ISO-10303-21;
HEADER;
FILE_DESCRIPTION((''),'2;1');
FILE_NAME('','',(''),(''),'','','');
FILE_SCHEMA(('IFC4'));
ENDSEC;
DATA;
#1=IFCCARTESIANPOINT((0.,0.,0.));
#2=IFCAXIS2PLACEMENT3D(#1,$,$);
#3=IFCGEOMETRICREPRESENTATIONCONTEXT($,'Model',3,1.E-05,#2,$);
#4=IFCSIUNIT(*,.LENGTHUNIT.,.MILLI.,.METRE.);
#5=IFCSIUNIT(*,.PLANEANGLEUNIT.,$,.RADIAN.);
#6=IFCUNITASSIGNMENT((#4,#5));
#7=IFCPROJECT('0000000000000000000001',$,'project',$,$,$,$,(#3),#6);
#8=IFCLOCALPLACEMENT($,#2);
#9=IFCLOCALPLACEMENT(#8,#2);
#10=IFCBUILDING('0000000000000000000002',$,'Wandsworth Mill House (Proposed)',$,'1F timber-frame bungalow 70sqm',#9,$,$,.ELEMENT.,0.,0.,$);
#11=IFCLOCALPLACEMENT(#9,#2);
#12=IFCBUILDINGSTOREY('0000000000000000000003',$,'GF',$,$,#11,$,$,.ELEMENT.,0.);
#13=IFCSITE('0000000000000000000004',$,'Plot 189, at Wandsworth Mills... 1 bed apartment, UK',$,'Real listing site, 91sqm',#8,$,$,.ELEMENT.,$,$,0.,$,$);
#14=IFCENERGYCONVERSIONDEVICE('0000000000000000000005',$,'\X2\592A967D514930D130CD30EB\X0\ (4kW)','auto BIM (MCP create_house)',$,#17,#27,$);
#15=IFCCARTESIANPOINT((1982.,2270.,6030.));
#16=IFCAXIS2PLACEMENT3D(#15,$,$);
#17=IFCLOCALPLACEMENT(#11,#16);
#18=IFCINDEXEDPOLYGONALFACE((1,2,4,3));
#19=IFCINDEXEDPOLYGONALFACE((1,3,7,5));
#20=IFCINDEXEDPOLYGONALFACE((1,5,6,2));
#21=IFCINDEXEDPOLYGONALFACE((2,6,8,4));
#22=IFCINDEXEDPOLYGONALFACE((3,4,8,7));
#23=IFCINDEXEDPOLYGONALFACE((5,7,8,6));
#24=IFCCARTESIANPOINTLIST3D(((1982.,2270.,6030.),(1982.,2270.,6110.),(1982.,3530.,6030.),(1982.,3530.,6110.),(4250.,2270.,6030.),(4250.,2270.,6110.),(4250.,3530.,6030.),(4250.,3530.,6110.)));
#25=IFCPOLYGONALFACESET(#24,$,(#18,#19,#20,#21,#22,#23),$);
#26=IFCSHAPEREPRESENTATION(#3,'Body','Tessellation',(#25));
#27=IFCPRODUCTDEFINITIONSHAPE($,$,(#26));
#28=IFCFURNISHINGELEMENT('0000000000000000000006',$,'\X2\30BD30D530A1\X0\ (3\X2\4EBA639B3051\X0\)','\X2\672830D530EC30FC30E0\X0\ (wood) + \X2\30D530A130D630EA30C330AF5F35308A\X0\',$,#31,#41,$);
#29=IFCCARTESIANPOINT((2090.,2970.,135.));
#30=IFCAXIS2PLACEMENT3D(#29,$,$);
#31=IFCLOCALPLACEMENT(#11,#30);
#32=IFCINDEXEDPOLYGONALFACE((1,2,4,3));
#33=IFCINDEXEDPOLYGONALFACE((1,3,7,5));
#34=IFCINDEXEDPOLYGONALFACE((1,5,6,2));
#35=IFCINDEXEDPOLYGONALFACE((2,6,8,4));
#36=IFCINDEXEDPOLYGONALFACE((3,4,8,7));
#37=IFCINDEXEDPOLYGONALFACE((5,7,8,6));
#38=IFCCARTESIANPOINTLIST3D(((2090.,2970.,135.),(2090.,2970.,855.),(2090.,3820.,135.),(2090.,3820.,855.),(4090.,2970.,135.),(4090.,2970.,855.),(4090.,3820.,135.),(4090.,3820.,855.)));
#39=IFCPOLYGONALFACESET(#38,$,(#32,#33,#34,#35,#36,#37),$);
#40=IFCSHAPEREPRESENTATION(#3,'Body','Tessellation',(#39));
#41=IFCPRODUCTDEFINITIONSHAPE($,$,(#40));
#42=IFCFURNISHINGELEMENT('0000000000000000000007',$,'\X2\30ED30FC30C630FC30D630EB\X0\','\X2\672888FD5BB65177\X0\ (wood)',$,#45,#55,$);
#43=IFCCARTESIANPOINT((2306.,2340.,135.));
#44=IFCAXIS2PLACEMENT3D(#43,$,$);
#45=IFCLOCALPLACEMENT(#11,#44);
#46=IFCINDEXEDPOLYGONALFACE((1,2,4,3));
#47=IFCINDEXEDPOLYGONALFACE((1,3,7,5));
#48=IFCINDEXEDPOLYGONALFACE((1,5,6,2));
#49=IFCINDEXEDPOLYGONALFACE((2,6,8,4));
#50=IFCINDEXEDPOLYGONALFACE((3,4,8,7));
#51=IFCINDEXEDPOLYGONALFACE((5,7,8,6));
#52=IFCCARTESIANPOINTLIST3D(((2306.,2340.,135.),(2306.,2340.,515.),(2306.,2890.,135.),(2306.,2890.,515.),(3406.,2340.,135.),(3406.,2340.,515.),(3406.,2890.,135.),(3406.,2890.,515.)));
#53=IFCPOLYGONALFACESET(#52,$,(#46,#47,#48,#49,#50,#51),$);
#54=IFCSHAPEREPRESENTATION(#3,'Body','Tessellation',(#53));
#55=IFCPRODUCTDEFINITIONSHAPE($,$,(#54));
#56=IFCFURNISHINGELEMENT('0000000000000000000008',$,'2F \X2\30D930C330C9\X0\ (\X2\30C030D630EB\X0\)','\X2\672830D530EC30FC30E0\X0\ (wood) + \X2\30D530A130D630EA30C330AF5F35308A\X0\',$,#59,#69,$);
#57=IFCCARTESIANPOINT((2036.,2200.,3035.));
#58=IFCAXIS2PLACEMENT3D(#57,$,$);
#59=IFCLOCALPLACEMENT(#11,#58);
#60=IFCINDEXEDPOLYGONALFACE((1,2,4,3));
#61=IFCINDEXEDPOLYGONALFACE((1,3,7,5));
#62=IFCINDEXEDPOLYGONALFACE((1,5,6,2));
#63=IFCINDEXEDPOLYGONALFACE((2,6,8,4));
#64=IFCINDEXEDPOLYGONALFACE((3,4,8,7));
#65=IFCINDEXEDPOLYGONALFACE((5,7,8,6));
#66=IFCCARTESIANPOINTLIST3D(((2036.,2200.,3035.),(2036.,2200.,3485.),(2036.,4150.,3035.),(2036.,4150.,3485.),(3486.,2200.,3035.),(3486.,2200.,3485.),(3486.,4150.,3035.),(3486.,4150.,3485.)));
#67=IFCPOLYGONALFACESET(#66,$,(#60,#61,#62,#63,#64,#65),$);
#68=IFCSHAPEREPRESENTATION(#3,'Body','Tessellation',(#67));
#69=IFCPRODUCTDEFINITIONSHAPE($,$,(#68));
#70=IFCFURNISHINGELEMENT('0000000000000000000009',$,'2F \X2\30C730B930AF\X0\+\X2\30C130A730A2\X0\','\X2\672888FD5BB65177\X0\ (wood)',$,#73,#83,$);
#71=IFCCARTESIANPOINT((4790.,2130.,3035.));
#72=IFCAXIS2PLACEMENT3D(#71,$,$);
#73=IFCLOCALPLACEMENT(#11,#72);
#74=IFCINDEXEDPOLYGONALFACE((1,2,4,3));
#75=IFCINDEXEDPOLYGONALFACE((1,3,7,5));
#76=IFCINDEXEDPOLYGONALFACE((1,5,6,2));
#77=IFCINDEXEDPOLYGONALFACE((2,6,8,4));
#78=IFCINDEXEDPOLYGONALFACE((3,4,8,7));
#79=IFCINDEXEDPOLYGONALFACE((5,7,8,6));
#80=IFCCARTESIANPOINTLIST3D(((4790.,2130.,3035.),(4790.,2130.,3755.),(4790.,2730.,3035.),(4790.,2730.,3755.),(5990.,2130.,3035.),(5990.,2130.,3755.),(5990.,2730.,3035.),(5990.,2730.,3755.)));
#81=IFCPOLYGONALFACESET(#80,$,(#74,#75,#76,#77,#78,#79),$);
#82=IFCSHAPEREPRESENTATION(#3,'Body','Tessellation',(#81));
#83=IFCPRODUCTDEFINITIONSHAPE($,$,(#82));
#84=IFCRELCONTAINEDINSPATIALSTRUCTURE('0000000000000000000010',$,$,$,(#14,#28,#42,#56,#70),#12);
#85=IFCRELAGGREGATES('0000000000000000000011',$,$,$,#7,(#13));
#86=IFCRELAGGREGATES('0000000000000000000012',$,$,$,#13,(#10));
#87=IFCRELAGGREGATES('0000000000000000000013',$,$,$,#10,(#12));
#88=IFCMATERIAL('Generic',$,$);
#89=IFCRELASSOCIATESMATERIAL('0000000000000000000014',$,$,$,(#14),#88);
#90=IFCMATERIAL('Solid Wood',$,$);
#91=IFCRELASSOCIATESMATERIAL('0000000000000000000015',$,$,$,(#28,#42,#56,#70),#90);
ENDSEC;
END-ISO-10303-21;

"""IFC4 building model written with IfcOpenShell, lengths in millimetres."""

from ifc_helpers import new_model, si_unit, frame, frame_2d, origin, place, context, project, spatial, rectangle, extrude, material, element, save


model = new_model("IFC4")

# Units and contexts
model_context = context("Model", 3, precision=1e-05, world=origin())
ifc_project = project(units=[si_unit("LENGTHUNIT", "METRE", prefix="MILLI"), si_unit("PLANEANGLEUNIT", "RADIAN")], contexts=[model_context])

# Site, building, storey
site_placement = place(None, origin())
site = spatial("IfcSite", under=ifc_project, at=site_placement, Name="Plot 189, at Wandsworth Mills... 1 bed apartment, UK", ObjectType="Real listing site, 91sqm", CompositionType="ELEMENT", RefElevation=0.0)
building_placement = place(site_placement, origin())
building = spatial("IfcBuilding", under=site, at=building_placement, Name="Wandsworth Mill House (Proposed)", ObjectType="1F timber-frame bungalow 70sqm", CompositionType="ELEMENT", ElevationOfRefHeight=0.0, ElevationOfTerrain=0.0)
storey_placement = place(building_placement, origin())
storey = spatial("IfcBuildingStorey", under=building, at=storey_placement, Name="GF", CompositionType="ELEMENT", Elevation=0.0)

# Shared definitions
ifc_material_1 = material(Name="Solid Wood")

# Shared definitions
ifc_material_2 = material(Name="Generic")

# Energy conversion device
energy_conversion_device_placement = place(storey_placement, frame((1982.0, 2270.0, 6030.0)))
element("IfcEnergyConversionDevice", 1, at=energy_conversion_device_placement, inside=storey, material=ifc_material_2, Name="太陽光パネル (4kW)", Description="auto BIM (MCP create_house)", context=model_context, shape_type="SweptSolid", body=[
    extrude(rectangle(XDim=2268.0, YDim=1260.0, at=frame_2d((1134.0, 630.0))), frame((1982.0, 2270.0, 6030.0)), (0.0, 0.0, 1.0), 80.0),
])

# Furnishing elements
furnishing_1_placement = place(storey_placement, frame((2090.0, 2970.0, 135.0)))
element("IfcFurnishingElement", 2, at=furnishing_1_placement, inside=storey, material=ifc_material_1, Name="ソファ (3人掛け)", Description="木フレーム (wood) + ファブリック張り", context=model_context, shape_type="SweptSolid", body=[
    extrude(rectangle(XDim=2000.0, YDim=850.0, at=frame_2d((1000.0, 425.0))), frame((2090.0, 2970.0, 135.0)), (0.0, 0.0, 1.0), 720.0),
])
furnishing_2_placement = place(storey_placement, frame((2306.0, 2340.0, 135.0)))
element("IfcFurnishingElement", 3, at=furnishing_2_placement, inside=storey, material=ifc_material_1, Name="ローテーブル", Description="木製家具 (wood)", context=model_context, shape_type="SweptSolid", body=[
    extrude(rectangle(XDim=1100.0, YDim=550.0, at=frame_2d((550.0, 275.0))), frame((2306.0, 2340.0, 135.0)), (0.0, 0.0, 1.0), 380.0),
])
furnishing_3_placement = place(storey_placement, frame((2036.0, 2200.0, 3035.0)))
element("IfcFurnishingElement", 4, at=furnishing_3_placement, inside=storey, material=ifc_material_1, Name="2F ベッド (ダブル)", Description="木フレーム (wood) + ファブリック張り", context=model_context, shape_type="SweptSolid", body=[
    extrude(rectangle(XDim=1450.0, YDim=1950.0, at=frame_2d((725.0, 975.0))), frame((2036.0, 2200.0, 3035.0)), (0.0, 0.0, 1.0), 450.0),
])
furnishing_4_placement = place(storey_placement, frame((4790.0, 2130.0, 3035.0)))
element("IfcFurnishingElement", 5, at=furnishing_4_placement, inside=storey, material=ifc_material_1, Name="2F デスク+チェア", Description="木製家具 (wood)", context=model_context, shape_type="SweptSolid", body=[
    extrude(rectangle(XDim=1200.0, YDim=600.0, at=frame_2d((600.0, 300.0))), frame((4790.0, 2130.0, 3035.0)), (0.0, 0.0, 1.0), 720.0),
])

save(model, "model.ifc")
